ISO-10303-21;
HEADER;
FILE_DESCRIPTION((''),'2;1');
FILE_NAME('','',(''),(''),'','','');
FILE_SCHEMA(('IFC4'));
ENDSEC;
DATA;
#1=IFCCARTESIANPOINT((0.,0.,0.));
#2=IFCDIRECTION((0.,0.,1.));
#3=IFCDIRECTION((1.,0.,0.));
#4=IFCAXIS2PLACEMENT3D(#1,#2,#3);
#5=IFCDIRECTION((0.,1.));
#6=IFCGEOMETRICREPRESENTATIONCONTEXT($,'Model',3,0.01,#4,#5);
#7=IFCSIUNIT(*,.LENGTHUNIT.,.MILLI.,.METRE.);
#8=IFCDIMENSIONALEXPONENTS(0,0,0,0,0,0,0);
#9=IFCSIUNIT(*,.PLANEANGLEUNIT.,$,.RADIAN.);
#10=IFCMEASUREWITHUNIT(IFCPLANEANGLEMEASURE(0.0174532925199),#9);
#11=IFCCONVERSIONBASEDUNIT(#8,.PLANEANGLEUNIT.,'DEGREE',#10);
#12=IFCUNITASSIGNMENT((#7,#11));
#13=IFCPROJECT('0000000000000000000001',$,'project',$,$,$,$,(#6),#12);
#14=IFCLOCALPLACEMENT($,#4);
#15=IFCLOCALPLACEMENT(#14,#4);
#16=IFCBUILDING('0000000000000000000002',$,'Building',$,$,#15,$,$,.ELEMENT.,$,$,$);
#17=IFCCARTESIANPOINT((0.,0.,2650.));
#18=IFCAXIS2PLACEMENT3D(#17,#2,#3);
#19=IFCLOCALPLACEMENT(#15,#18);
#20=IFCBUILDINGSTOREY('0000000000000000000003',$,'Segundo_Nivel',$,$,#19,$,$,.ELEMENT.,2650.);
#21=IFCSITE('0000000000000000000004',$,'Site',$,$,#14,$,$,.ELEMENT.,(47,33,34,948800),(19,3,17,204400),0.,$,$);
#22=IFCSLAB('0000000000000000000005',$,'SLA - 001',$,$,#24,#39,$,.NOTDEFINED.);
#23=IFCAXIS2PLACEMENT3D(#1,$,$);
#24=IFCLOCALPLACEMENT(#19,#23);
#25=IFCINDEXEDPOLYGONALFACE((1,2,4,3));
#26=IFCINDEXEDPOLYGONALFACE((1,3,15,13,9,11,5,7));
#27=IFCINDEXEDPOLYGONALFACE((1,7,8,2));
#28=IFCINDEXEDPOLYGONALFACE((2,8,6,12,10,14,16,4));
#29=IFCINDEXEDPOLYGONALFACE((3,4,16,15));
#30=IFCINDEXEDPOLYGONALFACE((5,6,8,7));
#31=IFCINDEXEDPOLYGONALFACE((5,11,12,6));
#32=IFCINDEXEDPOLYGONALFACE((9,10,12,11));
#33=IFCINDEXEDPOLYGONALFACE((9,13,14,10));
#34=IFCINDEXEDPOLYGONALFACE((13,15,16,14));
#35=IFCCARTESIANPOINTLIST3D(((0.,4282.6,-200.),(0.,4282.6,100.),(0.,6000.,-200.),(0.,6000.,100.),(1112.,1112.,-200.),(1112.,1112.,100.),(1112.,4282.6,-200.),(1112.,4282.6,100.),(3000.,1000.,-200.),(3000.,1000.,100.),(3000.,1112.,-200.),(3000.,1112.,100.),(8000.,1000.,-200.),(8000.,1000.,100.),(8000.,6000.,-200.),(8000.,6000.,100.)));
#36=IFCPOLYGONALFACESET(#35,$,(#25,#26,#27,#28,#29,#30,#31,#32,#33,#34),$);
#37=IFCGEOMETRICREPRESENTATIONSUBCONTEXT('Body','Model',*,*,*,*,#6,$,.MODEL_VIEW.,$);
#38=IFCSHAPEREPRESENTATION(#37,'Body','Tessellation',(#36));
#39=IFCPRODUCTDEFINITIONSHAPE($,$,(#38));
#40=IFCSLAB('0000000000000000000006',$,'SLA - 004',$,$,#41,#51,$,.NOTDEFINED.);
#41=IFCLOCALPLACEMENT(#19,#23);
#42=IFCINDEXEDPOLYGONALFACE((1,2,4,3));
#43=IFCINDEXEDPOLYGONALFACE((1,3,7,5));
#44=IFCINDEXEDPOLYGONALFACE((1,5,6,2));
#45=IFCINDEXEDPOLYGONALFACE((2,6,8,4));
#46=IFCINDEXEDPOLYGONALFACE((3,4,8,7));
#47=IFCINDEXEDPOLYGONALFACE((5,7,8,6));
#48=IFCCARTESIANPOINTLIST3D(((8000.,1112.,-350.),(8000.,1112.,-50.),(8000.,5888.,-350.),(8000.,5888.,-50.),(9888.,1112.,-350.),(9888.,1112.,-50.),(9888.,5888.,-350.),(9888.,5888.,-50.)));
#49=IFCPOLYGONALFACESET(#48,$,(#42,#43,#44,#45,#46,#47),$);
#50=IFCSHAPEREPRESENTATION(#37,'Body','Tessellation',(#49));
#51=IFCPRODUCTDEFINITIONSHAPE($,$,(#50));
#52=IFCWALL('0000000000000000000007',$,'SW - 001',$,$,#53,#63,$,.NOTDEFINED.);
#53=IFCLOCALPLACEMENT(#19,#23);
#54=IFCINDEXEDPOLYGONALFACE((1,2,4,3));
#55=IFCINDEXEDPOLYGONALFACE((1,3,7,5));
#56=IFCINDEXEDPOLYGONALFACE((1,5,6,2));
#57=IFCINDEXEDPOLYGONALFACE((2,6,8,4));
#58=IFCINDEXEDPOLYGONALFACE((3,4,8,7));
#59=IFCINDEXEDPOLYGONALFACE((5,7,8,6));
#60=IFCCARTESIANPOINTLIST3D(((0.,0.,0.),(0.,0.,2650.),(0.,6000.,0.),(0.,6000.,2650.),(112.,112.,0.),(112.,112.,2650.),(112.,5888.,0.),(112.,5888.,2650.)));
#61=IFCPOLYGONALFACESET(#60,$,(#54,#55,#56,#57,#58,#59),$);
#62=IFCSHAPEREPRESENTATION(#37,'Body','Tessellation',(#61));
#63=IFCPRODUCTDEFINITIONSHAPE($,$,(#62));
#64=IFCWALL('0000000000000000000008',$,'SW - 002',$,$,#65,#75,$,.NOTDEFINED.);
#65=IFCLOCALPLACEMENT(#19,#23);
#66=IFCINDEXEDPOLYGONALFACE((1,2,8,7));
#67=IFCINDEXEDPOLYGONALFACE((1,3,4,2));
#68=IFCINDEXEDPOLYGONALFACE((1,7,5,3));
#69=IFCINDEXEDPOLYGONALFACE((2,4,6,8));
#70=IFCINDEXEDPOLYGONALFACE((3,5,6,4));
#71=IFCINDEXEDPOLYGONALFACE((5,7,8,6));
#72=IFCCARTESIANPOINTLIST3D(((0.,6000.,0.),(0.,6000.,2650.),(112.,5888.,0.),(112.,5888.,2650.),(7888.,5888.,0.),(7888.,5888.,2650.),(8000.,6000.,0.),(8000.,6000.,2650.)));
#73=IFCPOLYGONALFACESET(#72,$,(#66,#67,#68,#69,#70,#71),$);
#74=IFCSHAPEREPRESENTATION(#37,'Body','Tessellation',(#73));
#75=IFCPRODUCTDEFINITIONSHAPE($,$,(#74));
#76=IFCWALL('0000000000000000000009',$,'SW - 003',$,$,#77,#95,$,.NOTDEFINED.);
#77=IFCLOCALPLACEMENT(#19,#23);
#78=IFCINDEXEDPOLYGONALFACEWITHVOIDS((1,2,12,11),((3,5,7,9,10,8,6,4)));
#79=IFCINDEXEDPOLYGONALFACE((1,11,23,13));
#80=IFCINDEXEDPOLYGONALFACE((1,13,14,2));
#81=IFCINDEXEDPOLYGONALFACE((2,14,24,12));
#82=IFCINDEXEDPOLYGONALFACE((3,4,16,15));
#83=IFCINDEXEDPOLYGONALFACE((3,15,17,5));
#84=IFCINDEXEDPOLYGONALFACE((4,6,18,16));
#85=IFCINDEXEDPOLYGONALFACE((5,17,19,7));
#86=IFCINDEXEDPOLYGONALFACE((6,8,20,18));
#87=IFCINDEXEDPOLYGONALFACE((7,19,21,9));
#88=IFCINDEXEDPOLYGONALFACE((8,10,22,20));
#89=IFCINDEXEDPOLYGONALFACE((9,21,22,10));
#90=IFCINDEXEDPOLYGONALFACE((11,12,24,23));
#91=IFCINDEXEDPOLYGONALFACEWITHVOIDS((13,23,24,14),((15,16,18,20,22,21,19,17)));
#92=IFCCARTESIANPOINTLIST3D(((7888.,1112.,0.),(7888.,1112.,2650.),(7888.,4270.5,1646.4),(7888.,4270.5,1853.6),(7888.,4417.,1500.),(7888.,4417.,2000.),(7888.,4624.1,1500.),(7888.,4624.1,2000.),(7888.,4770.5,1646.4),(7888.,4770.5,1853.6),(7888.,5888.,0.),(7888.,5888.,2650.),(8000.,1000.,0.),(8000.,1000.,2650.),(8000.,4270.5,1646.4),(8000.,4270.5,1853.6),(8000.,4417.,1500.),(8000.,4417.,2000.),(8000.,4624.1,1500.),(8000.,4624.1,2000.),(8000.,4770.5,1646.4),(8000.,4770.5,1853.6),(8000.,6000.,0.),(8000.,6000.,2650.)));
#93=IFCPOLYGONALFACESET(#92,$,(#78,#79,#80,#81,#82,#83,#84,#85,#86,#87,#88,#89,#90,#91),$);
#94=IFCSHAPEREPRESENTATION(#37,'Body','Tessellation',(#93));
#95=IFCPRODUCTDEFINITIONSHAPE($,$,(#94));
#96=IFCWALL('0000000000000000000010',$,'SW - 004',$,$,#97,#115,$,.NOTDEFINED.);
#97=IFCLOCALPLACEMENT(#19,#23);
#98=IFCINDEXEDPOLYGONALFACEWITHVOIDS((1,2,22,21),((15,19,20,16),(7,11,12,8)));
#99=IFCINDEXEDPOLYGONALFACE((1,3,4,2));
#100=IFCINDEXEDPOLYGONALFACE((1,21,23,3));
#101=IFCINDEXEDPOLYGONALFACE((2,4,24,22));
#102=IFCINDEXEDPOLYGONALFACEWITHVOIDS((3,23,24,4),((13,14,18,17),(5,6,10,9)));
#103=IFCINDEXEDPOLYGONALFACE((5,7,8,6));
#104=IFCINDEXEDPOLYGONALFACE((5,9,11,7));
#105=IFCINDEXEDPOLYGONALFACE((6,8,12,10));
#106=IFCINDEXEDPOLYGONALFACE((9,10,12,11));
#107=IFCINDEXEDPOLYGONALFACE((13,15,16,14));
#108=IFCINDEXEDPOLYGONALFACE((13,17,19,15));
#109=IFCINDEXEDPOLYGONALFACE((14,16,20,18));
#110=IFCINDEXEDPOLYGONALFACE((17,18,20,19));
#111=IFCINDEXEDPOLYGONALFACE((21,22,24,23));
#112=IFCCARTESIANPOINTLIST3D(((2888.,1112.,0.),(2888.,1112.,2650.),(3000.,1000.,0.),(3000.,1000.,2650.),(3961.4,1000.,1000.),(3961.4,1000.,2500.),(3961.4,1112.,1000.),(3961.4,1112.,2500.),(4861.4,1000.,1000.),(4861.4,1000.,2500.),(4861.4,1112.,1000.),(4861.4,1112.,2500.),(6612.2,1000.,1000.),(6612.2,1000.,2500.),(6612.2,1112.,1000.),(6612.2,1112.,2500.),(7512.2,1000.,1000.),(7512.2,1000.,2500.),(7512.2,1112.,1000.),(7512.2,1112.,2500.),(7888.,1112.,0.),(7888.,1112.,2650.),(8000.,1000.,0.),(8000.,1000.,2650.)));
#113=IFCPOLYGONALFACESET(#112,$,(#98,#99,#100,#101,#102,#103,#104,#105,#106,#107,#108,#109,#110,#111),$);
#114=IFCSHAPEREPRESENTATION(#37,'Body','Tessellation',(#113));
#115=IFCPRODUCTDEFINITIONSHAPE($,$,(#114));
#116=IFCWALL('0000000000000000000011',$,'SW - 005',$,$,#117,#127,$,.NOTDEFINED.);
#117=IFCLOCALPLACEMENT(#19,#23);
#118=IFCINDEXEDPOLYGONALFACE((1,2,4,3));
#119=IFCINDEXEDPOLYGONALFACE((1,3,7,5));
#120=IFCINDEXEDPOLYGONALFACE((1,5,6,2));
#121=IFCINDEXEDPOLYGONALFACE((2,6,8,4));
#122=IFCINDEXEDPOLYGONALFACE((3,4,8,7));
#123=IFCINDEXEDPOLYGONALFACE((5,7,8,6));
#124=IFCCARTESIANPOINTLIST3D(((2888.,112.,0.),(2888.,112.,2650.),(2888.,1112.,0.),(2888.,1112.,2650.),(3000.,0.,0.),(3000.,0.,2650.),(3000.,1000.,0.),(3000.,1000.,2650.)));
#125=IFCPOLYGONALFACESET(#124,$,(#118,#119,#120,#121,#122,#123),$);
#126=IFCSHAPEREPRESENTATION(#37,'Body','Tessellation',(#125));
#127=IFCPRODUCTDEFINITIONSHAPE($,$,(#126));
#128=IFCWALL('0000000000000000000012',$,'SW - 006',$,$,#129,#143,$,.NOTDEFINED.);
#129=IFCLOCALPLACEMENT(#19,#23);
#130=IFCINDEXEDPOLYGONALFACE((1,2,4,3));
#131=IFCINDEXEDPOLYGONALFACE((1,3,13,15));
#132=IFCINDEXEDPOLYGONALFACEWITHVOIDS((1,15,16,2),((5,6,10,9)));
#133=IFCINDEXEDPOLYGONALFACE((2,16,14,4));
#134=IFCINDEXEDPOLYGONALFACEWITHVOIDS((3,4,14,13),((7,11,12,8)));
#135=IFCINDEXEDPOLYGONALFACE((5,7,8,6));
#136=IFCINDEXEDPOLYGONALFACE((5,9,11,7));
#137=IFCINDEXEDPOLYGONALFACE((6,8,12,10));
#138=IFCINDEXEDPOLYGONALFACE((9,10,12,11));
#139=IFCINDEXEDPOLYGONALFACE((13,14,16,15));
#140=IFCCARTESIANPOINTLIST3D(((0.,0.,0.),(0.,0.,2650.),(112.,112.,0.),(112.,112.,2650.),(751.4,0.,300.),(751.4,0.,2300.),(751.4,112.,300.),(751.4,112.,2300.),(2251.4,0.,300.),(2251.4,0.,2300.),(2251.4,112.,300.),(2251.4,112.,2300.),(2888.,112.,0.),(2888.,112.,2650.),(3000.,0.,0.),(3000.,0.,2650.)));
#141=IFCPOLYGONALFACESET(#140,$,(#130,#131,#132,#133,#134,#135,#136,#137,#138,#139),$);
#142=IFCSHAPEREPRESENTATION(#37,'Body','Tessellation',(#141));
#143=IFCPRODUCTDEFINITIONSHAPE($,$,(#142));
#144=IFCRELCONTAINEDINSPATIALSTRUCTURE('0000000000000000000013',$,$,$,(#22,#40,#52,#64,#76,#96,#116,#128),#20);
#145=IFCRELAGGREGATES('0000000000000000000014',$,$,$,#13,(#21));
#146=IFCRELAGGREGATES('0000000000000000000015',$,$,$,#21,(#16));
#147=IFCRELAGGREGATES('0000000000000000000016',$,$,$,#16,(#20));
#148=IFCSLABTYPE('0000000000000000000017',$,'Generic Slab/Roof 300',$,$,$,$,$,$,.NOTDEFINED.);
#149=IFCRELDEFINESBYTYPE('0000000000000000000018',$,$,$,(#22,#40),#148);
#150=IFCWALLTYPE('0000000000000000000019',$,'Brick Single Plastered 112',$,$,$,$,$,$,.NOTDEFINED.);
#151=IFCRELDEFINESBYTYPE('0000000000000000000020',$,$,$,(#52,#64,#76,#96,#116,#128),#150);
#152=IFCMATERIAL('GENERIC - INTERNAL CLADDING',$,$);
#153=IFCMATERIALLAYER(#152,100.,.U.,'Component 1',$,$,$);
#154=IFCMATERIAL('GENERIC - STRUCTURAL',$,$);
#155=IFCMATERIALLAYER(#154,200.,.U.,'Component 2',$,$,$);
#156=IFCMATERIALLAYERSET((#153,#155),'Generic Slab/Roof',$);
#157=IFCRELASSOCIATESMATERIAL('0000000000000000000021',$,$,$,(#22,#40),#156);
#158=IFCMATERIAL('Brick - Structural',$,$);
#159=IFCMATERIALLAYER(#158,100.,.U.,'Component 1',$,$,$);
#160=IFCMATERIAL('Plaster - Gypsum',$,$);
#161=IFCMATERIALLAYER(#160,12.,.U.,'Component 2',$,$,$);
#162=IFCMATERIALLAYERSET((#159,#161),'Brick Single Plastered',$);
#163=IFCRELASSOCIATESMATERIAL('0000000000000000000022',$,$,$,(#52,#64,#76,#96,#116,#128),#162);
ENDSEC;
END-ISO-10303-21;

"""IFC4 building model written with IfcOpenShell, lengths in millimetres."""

from ifc_helpers import new_model, entity, si_unit, converted_unit, direction, frame, origin_with_axes, origin_2d_with_axis, place, context, subcontext, project, spatial, line, indexed_curve, rectangle, outline, extrude, material, layer, layer_set, layer_usage, type_object, element, save


model = new_model("IFC4")

# Units and contexts
model_context = context("Model", 3, precision=0.01, world=origin_with_axes(), true_north=direction((0.0, 1.0)))
body_context = subcontext(model_context, "Body", "Model", "MODEL_VIEW")
ifc_project = project(units=[si_unit("LENGTHUNIT", "METRE", prefix="MILLI"), converted_unit("PLANEANGLEUNIT", "DEGREE", entity("IfcPlaneAngleMeasure", 0.0174532925199), si_unit("PLANEANGLEUNIT", "RADIAN"), dimensions=[0, 0, 0, 0, 0, 0, 0])], contexts=[model_context])

# Site, building, storey
site_placement = place(None, origin_with_axes())
site = spatial("IfcSite", under=ifc_project, at=site_placement, Name="Site", CompositionType="ELEMENT", RefLatitude=(47, 33, 34, 948800), RefLongitude=(19, 3, 17, 204400), RefElevation=0.0)
building_placement = place(site_placement, origin_with_axes())
building = spatial("IfcBuilding", under=site, at=building_placement, Name="Building", CompositionType="ELEMENT")
storey_placement = place(building_placement, frame((0.0, 0.0, 2650.0), z_axis=(0.0, 0.0, 1.0), x_axis=(1.0, 0.0, 0.0)))
storey = spatial("IfcBuildingStorey", under=building, at=storey_placement, Name="Segundo_Nivel", CompositionType="ELEMENT", Elevation=2650.0)

# Slabs
ifc_material_1 = material(Name="GENERIC - INTERNAL CLADDING")
ifc_layer_1 = layer(ifc_material_1, 100.0, ventilated="UNKNOWN", Name="Component 1")
ifc_material_2 = material(Name="GENERIC - STRUCTURAL")
ifc_layer_2 = layer(ifc_material_2, 200.0, ventilated="UNKNOWN", Name="Component 2")
ifc_layer_set_1 = layer_set([ifc_layer_1, ifc_layer_2], Name="Generic Slab/Roof")
ifc_layer_usage_1 = layer_usage(ifc_layer_set_1, "AXIS3", "NEGATIVE", 300.0)
slab_type = type_object("IfcSlabType", Name="Generic Slab/Roof 300", PredefinedType="NOTDEFINED")
slab_1_placement = place(storey_placement, frame((1112.0, 1112.0, 0.0), z_axis=(0.0, 0.0, 1.0), x_axis=(1.0, 0.0, 0.0)))
element("IfcSlab", 1, at=slab_1_placement, inside=storey, type_object=slab_type, material=ifc_layer_usage_1, Name="SLA - 001", PredefinedType="NOTDEFINED", context=body_context, shape_type="SweptSolid", body=[
    extrude(outline(indexed_curve([(0.0, 0.0), (1888.0, 0.0), (1888.0, -112.0), (6888.0, -112.0), (6888.0, 4888.0), (-1112.0, 4888.0), (-1112.0, 3170.6), (0.0, 3170.6)], segments=[line(1, 2, 3, 4, 5, 6, 7, 8, 1)])), frame((0.0, 0.0, -200.0), z_axis=(0.0, 0.0, 1.0), x_axis=(1.0, 0.0, 0.0)), (0.0, 0.0, 1.0), 300.0),
])
ifc_layer_usage_2 = layer_usage(ifc_layer_set_1, "AXIS3", "NEGATIVE", 300.0)
slab_2_placement = place(storey_placement, frame((8000.0, 5888.0, -150.0), z_axis=(0.0, 0.0, 1.0), x_axis=(1.0, 0.0, 0.0)))
element("IfcSlab", 2, at=slab_2_placement, inside=storey, type_object=slab_type, material=ifc_layer_usage_2, Name="SLA - 004", PredefinedType="NOTDEFINED", context=body_context, shape_type="SweptSolid", body=[
    extrude(outline(indexed_curve([(0.0, 0.0), (0.0, -4776.0), (1888.0, -4776.0), (1888.0, 0.0)], segments=[line(1, 2, 3, 4, 1)])), frame((0.0, 0.0, -200.0), z_axis=(0.0, 0.0, 1.0), x_axis=(1.0, 0.0, 0.0)), (0.0, 0.0, 1.0), 300.0),
])

# Walls
ifc_material_3 = material(Name="Brick - Structural")
ifc_layer_3 = layer(ifc_material_3, 100.0, ventilated="UNKNOWN", Name="Component 1")
ifc_material_4 = material(Name="Plaster - Gypsum")
ifc_layer_4 = layer(ifc_material_4, 12.0, ventilated="UNKNOWN", Name="Component 2")
ifc_layer_set_2 = layer_set([ifc_layer_3, ifc_layer_4], Name="Brick Single Plastered")
ifc_layer_usage_3 = layer_usage(ifc_layer_set_2, "AXIS2", "NEGATIVE", 0.0)
wall_type_1 = type_object("IfcWallType", Name="Brick Single Plastered 112", PredefinedType="NOTDEFINED")
wall_1_placement = place(storey_placement, frame((0.0, 0.0, 0.0), z_axis=(0.0, 0.0, 1.0), x_axis=(0.0, 1.0, 0.0)))
element("IfcWall", 3, at=wall_1_placement, inside=storey, type_object=wall_type_1, material=ifc_layer_usage_3, Name="SW - 001", PredefinedType="NOTDEFINED", context=body_context, shape_type="SweptSolid", body=[
    extrude(outline(indexed_curve([(112.0, -112.0), (5888.0, -112.0), (6000.0, 0.0), (0.0, 0.0)], segments=[line(1, 2, 3, 4, 1)])), origin_with_axes(), (0.0, 0.0, 1.0), 2650.0),
])
ifc_layer_usage_4 = layer_usage(ifc_layer_set_2, "AXIS2", "NEGATIVE", 0.0)
wall_2_placement = place(storey_placement, frame((0.0, 6000.0, 0.0), z_axis=(0.0, 0.0, 1.0), x_axis=(1.0, 0.0, 0.0)))
element("IfcWall", 4, at=wall_2_placement, inside=storey, type_object=wall_type_1, material=ifc_layer_usage_4, Name="SW - 002", PredefinedType="NOTDEFINED", context=body_context, shape_type="SweptSolid", body=[
    extrude(outline(indexed_curve([(112.0, -112.0), (7888.0, -112.0), (8000.0, 0.0), (0.0, 0.0)], segments=[line(1, 2, 3, 4, 1)])), origin_with_axes(), (0.0, 0.0, 1.0), 2650.0),
])

# Wall, opening
ifc_layer_usage_5 = layer_usage(ifc_layer_set_2, "AXIS2", "NEGATIVE", 0.0)
wall_3_placement = place(storey_placement, frame((8000.0, 6000.0, 0.0), z_axis=(0.0, 0.0, 1.0), x_axis=(0.0, -1.0, 0.0)))
wall_3 = element("IfcWall", 5, at=wall_3_placement, inside=storey, type_object=wall_type_1, material=ifc_layer_usage_5, Name="SW - 003", PredefinedType="NOTDEFINED", context=body_context, shape_type="SweptSolid", body=[
    extrude(outline(indexed_curve([(112.0, -112.0), (4888.0, -112.0), (5000.0, 0.0), (0.0, 0.0)], segments=[line(1, 2, 3, 4, 1)])), origin_with_axes(), (0.0, 0.0, 1.0), 2650.0),
])
opening_1_placement = place(wall_3_placement, frame((1479.5, 0.0, 1500.0), z_axis=(0.0, 0.0, 1.0), x_axis=(1.0, 0.0, 0.0)))
element("IfcOpeningElement", 6, at=opening_1_placement, cuts=wall_3, context=body_context, shape_type="SweptSolid", body=[
    extrude(outline(indexed_curve([(103.6, -500.0), (250.0, -353.6), (250.0, -146.4), (103.6, 0.0), (-103.6, 0.0), (-250.0, -146.4), (-250.0, -353.6), (-103.6, -500.0)], segments=[line(1, 2, 3, 4, 5, 6, 7, 8, 1)])), frame((0.0, -112.0, 0.0), z_axis=(0.0, 1.0, 0.0), x_axis=(1.0, 0.0, 0.0)), (0.0, 0.0, 1.0), 336.0),
])

# Wall, openings
ifc_layer_usage_6 = layer_usage(ifc_layer_set_2, "AXIS2", "NEGATIVE", 0.0)
wall_4_placement = place(storey_placement, frame((8000.0, 1000.0, 0.0), z_axis=(0.0, 0.0, 1.0), x_axis=(-1.0, 0.0, 0.0)))
wall_4 = element("IfcWall", 7, at=wall_4_placement, inside=storey, type_object=wall_type_1, material=ifc_layer_usage_6, Name="SW - 004", PredefinedType="NOTDEFINED", context=body_context, shape_type="SweptSolid", body=[
    extrude(outline(indexed_curve([(112.0, -112.0), (5112.0, -112.0), (5000.0, 0.0), (0.0, 0.0)], segments=[line(1, 2, 3, 4, 1)])), origin_with_axes(), (0.0, 0.0, 1.0), 2650.0),
])
opening_2_placement = place(wall_4_placement, frame((937.8, 0.0, 1000.0), z_axis=(0.0, 0.0, 1.0), x_axis=(1.0, 0.0, 0.0)))
element("IfcOpeningElement", 8, at=opening_2_placement, cuts=wall_4, context=body_context, shape_type="SweptSolid", body=[
    extrude(rectangle(XDim=900.0, YDim=1500.0, at=origin_2d_with_axis()), frame((0.0, -112.0, 750.0), z_axis=(0.0, -1.0, 0.0), x_axis=(-1.0, 0.0, 0.0)), (0.0, 0.0, -1.0), 336.0),
])
opening_3_placement = place(wall_4_placement, frame((3588.6, 0.0, 1000.0), z_axis=(0.0, 0.0, 1.0), x_axis=(1.0, 0.0, 0.0)))
element("IfcOpeningElement", 9, at=opening_3_placement, cuts=wall_4, context=body_context, shape_type="SweptSolid", body=[
    extrude(rectangle(XDim=900.0, YDim=1500.0, at=origin_2d_with_axis()), frame((0.0, -112.0, 750.0), z_axis=(0.0, -1.0, 0.0), x_axis=(-1.0, 0.0, 0.0)), (0.0, 0.0, -1.0), 336.0),
])

# Wall
ifc_layer_usage_7 = layer_usage(ifc_layer_set_2, "AXIS2", "NEGATIVE", 0.0)
wall_5_placement = place(storey_placement, frame((3000.0, 1000.0, 0.0), z_axis=(0.0, 0.0, 1.0), x_axis=(0.0, -1.0, 0.0)))
element("IfcWall", 10, at=wall_5_placement, inside=storey, type_object=wall_type_1, material=ifc_layer_usage_7, Name="SW - 005", PredefinedType="NOTDEFINED", context=body_context, shape_type="SweptSolid", body=[
    extrude(outline(indexed_curve([(-112.0, -112.0), (888.0, -112.0), (1000.0, 0.0), (0.0, 0.0)], segments=[line(1, 2, 3, 4, 1)])), origin_with_axes(), (0.0, 0.0, 1.0), 2650.0),
])

# Wall, opening
ifc_layer_usage_8 = layer_usage(ifc_layer_set_2, "AXIS2", "NEGATIVE", 0.0)
wall_6_placement = place(storey_placement, frame((3000.0, 0.0, 0.0), z_axis=(0.0, 0.0, 1.0), x_axis=(-1.0, 0.0, 0.0)))
wall_6 = element("IfcWall", 11, at=wall_6_placement, inside=storey, type_object=wall_type_1, material=ifc_layer_usage_8, Name="SW - 006", PredefinedType="NOTDEFINED", context=body_context, shape_type="SweptSolid", body=[
    extrude(outline(indexed_curve([(112.0, -112.0), (2888.0, -112.0), (3000.0, 0.0), (0.0, 0.0)], segments=[line(1, 2, 3, 4, 1)])), origin_with_axes(), (0.0, 0.0, 1.0), 2650.0),
])
opening_4_placement = place(wall_6_placement, frame((1498.6, 0.0, 300.0), z_axis=(0.0, 0.0, 1.0), x_axis=(1.0, 0.0, 0.0)))
element("IfcOpeningElement", 12, at=opening_4_placement, cuts=wall_6, context=body_context, shape_type="SweptSolid", body=[
    extrude(rectangle(XDim=1500.0, YDim=2000.0, at=origin_2d_with_axis()), frame((0.0, -112.0, 1000.0), z_axis=(0.0, 1.0, 0.0), x_axis=(-1.0, 0.0, 0.0)), (0.0, 0.0, 1.0), 336.0),
])

save(model, "model.ifc")
